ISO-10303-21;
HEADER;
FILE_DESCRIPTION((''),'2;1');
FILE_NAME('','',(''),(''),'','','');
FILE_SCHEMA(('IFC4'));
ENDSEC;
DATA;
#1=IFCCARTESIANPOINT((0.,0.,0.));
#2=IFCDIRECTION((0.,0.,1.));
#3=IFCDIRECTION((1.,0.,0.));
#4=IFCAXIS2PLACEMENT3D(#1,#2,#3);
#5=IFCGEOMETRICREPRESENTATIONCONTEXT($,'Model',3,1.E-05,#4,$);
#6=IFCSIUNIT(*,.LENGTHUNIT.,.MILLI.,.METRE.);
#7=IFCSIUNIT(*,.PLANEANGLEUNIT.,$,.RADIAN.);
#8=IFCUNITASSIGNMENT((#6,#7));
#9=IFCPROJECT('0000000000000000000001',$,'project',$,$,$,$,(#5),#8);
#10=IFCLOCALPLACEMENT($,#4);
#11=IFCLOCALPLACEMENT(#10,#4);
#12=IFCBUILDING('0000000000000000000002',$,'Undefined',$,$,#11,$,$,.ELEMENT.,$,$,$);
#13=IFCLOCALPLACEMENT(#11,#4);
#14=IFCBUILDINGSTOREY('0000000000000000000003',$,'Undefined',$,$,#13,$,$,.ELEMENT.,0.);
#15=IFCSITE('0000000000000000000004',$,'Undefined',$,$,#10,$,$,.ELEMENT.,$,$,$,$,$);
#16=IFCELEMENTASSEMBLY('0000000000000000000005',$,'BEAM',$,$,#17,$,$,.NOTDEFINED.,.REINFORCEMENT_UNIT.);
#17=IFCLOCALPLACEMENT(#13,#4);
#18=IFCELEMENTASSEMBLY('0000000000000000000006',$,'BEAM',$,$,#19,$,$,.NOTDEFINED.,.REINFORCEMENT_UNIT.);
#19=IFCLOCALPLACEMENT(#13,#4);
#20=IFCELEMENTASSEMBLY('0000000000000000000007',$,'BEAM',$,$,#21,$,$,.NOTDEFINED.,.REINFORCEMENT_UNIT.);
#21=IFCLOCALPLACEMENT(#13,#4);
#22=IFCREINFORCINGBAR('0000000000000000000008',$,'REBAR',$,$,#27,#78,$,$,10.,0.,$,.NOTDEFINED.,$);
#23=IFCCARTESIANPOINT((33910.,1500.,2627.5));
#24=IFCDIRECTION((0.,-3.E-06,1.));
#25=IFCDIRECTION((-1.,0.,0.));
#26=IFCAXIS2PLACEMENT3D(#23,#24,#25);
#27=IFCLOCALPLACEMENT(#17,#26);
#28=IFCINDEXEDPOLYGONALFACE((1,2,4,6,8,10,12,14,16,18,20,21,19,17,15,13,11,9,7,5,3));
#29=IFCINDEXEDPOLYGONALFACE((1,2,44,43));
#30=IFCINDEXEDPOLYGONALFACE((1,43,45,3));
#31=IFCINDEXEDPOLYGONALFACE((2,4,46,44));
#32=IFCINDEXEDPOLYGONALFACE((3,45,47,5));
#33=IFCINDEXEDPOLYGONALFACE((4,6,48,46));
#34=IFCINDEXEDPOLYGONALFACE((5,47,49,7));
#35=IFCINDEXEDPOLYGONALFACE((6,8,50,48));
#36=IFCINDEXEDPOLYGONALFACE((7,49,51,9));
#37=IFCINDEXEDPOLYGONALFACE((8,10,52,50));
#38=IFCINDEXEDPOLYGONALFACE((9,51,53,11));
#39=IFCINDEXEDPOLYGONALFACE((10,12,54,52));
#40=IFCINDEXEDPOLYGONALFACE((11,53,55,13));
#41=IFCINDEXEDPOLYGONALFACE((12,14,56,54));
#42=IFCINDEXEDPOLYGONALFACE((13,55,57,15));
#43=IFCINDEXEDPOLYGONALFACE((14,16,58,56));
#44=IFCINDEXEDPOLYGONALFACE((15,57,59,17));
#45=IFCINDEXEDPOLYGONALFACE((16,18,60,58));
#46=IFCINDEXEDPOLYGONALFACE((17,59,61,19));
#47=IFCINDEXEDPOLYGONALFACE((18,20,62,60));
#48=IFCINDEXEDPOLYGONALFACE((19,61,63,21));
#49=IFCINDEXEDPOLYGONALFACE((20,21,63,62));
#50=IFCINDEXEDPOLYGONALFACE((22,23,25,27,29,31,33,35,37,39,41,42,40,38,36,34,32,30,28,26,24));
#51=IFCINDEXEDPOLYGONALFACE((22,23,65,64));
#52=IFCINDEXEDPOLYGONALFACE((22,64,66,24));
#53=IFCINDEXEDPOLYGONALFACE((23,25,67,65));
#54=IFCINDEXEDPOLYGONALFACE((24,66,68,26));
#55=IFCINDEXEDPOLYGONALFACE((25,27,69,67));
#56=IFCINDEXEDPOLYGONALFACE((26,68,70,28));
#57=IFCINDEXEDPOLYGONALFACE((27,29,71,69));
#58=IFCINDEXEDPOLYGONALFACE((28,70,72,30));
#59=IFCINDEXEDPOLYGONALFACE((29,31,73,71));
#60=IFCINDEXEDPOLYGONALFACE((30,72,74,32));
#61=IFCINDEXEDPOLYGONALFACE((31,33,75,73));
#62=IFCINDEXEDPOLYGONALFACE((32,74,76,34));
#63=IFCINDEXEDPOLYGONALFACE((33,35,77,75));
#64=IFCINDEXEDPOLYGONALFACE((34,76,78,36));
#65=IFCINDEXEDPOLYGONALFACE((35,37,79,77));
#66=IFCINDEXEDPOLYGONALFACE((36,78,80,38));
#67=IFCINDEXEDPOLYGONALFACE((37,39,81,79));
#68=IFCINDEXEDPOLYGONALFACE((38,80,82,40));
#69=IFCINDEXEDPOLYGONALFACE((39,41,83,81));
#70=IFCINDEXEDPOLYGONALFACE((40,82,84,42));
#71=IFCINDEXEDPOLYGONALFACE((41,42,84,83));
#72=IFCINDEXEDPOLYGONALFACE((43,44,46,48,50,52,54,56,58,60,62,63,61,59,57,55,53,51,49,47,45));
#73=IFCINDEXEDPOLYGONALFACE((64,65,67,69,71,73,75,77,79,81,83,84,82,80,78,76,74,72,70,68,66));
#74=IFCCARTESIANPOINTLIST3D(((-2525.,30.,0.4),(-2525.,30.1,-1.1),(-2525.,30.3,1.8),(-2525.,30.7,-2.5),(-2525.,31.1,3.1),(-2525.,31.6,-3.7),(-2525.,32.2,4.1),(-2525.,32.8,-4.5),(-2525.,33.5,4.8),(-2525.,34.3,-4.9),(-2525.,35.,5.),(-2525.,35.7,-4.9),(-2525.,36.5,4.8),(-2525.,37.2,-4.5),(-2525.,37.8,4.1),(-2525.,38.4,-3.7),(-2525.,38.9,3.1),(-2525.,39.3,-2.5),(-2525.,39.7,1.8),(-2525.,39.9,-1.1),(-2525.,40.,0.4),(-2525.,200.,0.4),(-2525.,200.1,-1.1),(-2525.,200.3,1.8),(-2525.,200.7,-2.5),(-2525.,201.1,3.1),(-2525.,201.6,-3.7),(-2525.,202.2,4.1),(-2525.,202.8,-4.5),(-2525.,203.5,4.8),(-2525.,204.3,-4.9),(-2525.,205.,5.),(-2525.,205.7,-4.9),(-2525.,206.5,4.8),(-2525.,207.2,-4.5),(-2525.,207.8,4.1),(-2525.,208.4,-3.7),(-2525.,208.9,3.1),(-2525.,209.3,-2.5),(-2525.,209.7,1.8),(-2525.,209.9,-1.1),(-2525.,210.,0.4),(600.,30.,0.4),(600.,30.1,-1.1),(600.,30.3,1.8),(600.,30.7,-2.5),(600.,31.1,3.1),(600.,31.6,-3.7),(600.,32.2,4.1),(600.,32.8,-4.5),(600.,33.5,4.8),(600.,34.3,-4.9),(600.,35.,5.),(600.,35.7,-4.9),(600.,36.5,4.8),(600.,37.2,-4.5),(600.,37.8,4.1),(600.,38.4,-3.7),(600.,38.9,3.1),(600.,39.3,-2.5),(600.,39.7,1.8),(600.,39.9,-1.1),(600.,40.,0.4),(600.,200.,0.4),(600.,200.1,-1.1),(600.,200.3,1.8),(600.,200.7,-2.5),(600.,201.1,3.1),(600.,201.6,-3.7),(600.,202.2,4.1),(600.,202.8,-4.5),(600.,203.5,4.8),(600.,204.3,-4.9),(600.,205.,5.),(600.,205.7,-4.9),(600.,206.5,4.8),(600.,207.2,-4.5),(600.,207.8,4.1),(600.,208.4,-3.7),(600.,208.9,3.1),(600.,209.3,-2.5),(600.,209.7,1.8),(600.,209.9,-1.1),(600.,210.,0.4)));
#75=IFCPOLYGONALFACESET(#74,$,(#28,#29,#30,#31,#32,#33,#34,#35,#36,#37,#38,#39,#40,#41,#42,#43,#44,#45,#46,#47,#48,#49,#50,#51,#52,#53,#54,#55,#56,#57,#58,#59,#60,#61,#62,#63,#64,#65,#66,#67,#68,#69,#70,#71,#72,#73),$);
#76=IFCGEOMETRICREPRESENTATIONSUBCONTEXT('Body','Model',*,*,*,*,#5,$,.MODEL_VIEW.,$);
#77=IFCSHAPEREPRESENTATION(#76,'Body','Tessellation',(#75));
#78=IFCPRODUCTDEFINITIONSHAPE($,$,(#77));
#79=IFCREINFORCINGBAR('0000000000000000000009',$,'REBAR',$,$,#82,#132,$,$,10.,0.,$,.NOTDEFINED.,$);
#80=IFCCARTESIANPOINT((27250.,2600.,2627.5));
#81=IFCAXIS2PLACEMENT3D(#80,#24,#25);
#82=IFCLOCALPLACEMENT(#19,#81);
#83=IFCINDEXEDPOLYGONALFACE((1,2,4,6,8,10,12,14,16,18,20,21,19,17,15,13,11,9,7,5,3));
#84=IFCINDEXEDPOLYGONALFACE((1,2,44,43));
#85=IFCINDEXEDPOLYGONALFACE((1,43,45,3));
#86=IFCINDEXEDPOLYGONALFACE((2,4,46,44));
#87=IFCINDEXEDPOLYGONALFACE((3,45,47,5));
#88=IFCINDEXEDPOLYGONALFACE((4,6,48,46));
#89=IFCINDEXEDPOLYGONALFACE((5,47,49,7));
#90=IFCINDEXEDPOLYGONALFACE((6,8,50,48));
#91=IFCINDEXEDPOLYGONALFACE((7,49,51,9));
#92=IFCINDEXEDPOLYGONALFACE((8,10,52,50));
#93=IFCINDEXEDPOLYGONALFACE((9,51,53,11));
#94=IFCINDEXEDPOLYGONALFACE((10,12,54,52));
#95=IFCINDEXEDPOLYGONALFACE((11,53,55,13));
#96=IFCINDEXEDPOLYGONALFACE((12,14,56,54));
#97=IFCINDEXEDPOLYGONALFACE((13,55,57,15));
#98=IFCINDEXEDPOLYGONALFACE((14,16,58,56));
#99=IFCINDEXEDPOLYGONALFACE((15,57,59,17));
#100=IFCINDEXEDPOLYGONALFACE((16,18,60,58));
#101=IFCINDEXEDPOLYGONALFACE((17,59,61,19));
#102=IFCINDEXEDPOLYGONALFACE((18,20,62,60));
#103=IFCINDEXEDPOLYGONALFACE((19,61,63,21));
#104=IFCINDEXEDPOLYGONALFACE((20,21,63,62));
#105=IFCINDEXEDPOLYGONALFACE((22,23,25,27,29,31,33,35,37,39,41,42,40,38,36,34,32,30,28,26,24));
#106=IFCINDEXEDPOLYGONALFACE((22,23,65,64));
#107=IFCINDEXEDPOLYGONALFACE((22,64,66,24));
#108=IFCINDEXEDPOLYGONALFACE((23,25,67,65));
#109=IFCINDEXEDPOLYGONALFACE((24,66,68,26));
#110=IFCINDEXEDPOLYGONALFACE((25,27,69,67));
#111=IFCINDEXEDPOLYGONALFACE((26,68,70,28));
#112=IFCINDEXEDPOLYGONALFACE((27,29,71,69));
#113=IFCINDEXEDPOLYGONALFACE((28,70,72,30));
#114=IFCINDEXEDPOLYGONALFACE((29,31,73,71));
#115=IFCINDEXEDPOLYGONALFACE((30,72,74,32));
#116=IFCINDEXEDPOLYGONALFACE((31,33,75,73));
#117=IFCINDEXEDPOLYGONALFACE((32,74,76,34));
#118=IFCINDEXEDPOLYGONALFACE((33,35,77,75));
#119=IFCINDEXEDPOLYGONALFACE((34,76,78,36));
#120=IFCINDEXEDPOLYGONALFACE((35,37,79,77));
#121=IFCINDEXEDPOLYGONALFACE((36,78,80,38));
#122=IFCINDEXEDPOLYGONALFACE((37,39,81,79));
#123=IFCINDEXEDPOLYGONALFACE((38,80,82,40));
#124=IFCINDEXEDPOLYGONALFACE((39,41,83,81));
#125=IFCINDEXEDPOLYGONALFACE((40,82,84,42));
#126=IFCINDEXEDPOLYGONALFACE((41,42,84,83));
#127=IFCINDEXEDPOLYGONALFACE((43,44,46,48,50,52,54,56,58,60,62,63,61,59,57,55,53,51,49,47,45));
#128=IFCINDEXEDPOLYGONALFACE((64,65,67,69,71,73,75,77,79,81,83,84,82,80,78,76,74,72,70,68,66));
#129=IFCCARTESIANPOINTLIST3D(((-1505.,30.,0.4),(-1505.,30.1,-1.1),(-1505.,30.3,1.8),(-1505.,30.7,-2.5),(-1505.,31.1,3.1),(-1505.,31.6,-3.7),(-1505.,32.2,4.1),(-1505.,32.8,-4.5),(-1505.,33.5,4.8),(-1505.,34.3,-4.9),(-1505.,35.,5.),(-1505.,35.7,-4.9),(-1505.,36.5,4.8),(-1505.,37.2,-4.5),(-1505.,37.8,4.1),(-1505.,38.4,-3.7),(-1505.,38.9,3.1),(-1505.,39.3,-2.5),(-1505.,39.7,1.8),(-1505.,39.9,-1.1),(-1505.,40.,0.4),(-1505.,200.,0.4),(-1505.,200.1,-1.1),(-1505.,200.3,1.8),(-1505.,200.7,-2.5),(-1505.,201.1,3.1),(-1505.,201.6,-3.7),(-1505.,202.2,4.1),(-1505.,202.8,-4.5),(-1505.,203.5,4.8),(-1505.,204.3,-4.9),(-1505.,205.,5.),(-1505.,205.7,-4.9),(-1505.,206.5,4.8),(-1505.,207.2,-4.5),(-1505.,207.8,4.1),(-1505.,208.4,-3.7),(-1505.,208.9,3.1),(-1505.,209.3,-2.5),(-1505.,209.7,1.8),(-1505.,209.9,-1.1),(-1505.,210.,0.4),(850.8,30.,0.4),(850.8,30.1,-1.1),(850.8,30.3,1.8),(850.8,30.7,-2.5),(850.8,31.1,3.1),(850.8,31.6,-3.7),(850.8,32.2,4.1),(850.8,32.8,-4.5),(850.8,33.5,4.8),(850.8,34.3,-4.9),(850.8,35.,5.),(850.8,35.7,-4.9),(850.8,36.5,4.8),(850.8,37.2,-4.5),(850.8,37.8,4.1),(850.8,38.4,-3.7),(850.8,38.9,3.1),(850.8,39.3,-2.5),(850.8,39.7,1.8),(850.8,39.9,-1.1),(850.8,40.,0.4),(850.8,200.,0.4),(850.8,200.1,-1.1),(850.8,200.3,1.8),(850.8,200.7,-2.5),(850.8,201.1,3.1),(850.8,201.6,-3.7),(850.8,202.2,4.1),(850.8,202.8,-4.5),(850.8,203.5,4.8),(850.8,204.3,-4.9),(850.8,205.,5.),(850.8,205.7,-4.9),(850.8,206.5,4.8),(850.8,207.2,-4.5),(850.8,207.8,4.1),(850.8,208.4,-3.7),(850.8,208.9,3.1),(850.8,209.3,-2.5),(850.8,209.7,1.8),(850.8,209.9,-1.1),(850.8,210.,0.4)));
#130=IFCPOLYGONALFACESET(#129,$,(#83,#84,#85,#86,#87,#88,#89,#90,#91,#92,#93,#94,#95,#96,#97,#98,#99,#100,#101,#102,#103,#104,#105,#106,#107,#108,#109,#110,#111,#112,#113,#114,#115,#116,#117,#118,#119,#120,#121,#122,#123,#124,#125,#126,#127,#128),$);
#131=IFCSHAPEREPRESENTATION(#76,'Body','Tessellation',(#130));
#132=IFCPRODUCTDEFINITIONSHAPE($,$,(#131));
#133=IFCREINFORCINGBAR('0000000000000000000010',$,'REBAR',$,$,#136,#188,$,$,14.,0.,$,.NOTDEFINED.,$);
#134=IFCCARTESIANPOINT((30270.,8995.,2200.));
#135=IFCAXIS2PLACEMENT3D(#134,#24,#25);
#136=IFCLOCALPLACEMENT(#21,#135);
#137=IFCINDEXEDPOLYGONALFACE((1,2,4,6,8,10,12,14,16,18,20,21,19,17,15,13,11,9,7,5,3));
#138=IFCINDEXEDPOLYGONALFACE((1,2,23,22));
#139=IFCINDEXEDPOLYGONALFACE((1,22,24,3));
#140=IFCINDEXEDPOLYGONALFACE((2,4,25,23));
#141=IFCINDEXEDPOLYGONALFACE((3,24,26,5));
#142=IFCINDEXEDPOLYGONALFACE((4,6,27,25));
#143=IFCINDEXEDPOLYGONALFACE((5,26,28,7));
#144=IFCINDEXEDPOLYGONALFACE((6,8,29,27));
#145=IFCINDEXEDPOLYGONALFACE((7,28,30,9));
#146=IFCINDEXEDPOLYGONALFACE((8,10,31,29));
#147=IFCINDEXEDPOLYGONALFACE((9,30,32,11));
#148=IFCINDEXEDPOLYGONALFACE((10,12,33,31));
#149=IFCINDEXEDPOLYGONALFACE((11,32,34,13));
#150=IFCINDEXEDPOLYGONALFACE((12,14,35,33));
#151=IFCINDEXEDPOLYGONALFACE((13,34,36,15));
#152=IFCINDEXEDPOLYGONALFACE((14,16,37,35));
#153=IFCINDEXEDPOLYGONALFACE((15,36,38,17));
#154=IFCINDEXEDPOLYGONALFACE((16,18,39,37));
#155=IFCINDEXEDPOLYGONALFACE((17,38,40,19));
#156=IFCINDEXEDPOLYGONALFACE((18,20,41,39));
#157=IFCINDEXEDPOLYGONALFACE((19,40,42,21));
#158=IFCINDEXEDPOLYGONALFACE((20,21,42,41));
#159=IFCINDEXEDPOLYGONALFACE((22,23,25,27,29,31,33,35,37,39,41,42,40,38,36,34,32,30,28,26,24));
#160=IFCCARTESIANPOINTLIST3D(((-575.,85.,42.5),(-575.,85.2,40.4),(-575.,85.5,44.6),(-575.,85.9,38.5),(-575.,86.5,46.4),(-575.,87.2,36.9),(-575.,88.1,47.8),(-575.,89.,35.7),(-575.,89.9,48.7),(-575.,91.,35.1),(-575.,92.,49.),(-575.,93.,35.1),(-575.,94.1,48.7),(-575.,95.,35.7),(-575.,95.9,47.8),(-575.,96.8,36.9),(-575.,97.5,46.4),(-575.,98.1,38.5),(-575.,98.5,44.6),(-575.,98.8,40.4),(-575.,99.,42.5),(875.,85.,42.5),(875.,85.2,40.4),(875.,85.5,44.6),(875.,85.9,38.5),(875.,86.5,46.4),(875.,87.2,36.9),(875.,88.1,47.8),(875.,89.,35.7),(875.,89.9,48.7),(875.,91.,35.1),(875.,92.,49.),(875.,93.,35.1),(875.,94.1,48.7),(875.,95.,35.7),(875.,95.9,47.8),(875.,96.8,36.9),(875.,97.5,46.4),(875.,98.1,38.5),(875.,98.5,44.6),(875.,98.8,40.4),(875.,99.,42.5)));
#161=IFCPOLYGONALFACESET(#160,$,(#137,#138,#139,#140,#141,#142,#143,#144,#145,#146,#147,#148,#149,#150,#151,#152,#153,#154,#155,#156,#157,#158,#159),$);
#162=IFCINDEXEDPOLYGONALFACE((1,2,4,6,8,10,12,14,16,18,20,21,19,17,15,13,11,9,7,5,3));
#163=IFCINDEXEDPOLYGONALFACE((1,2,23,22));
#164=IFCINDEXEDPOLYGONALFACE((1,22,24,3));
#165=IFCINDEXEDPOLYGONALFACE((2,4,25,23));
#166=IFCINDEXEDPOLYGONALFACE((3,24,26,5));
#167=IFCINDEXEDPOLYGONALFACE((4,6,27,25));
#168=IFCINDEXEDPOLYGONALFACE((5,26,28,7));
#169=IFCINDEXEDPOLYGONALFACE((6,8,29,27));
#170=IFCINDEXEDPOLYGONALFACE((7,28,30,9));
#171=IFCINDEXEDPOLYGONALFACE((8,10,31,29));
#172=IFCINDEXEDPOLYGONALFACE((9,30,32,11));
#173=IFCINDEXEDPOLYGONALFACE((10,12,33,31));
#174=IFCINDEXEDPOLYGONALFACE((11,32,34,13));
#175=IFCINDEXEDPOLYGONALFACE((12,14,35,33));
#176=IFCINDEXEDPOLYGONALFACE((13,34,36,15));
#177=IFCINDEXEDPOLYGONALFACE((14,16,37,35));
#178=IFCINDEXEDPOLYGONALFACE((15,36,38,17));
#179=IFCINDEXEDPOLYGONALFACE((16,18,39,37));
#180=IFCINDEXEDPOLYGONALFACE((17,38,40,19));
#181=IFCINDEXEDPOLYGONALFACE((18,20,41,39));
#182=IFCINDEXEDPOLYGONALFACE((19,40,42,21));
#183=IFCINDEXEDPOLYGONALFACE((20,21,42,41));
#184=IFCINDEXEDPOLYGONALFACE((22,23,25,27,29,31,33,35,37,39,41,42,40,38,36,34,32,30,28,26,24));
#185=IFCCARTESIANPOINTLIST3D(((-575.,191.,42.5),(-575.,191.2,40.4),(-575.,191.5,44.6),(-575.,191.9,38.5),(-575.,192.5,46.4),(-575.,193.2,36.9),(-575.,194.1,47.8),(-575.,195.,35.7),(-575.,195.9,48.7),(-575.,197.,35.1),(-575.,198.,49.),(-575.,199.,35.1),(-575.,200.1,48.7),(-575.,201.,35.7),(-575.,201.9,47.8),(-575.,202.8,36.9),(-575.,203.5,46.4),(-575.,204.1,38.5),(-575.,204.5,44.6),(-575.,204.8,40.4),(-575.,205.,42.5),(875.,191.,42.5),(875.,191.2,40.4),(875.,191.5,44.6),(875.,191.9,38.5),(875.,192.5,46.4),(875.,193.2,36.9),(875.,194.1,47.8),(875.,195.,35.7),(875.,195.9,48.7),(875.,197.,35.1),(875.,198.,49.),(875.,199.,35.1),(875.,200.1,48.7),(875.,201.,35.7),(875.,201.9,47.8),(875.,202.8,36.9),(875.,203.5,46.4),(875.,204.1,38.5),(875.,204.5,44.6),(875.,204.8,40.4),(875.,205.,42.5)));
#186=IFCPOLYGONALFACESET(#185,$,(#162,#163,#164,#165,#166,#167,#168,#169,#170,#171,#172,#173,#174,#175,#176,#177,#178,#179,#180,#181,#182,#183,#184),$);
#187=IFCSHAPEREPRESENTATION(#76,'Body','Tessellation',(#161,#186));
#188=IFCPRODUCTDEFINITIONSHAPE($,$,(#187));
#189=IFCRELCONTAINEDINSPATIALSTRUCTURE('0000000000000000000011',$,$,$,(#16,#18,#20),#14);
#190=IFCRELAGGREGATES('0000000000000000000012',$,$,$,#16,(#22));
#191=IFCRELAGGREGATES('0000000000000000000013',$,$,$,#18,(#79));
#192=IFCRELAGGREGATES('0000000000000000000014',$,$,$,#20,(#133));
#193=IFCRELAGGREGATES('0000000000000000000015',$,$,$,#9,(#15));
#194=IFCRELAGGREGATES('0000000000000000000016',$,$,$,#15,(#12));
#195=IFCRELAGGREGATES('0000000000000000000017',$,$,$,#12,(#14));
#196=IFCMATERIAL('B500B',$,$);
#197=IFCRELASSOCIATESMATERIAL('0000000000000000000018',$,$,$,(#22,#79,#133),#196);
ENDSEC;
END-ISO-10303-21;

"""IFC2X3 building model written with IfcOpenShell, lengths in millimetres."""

from ifc_helpers import new_model, entity, si_unit, frame, origin_with_axes, place, context, subcontext, project, spatial, source, transform, mapped, material, element, aggregate, save


model = new_model("IFC2X3")

# Units and contexts
model_context = context("Model", 3, precision=1e-05, world=origin_with_axes())
body_context = subcontext(model_context, "Body", "Model", "MODEL_VIEW")
ifc_project = project(units=[si_unit("LENGTHUNIT", "METRE", prefix="MILLI"), si_unit("PLANEANGLEUNIT", "RADIAN")], contexts=[model_context])

# Site, building, storey
site_placement = place(None, origin_with_axes())
site = spatial("IfcSite", under=ifc_project, at=site_placement, Name="Undefined", CompositionType="ELEMENT")
building_placement = place(site_placement, origin_with_axes())
building = spatial("IfcBuilding", under=site, at=building_placement, Name="Undefined", CompositionType="ELEMENT")
storey_placement = place(building_placement, origin_with_axes())
storey = spatial("IfcBuildingStorey", under=building, at=storey_placement, Name="Undefined", CompositionType="ELEMENT", Elevation=0.0)

# Element assembly
assembly_1_placement = place(storey_placement, origin_with_axes())
assembly_1 = element("IfcElementAssembly", 1, at=assembly_1_placement, inside=storey, Name="BEAM", AssemblyPlace="NOTDEFINED", PredefinedType="REINFORCEMENT_UNIT")

# Element assembly
assembly_2_placement = place(storey_placement, origin_with_axes())
assembly_2 = element("IfcElementAssembly", 2, at=assembly_2_placement, inside=storey, Name="BEAM", AssemblyPlace="NOTDEFINED", PredefinedType="REINFORCEMENT_UNIT")

# Element assembly
assembly_3_placement = place(storey_placement, origin_with_axes())
assembly_3 = element("IfcElementAssembly", 3, at=assembly_3_placement, inside=storey, Name="BEAM", AssemblyPlace="NOTDEFINED", PredefinedType="REINFORCEMENT_UNIT")

# Reinforcing bars
ifc_material_1 = material(Name="B500B")
shared_shape_1 = source(origin_with_axes(), body_context, "Body", "AdvancedSweptSolid", [
    entity("IfcSweptDiskSolid", entity("IfcTrimmedCurve", entity("IfcLine", entity("IfcCartesianPoint", [0.0, 0.0, 0.0]), entity("IfcVector", entity("IfcDirection", [1.0, 0.0, 0.0]), 1.0)), [entity("IfcParameterValue", 0.0)], [entity("IfcParameterValue", 3125.002834)], True, "PARAMETER"), 5.0, None, 0.0, 3125.0),
])
shared_shape_2 = source(origin_with_axes(), body_context, "Body", "AdvancedSweptSolid", [
    entity("IfcSweptDiskSolid", entity("IfcTrimmedCurve", entity("IfcLine", entity("IfcCartesianPoint", [0.0, 0.0, 0.0]), entity("IfcVector", entity("IfcDirection", [1.0, 0.0, 0.0]), 1.0)), [entity("IfcParameterValue", 0.0)], [entity("IfcParameterValue", 3125.002834)], True, "PARAMETER"), 5.0, None, 0.0, 3125.0),
])
reinforcing_bar_1_placement = place(assembly_1_placement, frame((33910.0, 1500.0, 2627.5), z_axis=(0.0, -0.000003, 1.0), x_axis=(-1.0, 0.0, 0.0)))
reinforcing_bar_1 = element("IfcReinforcingBar", 4, at=reinforcing_bar_1_placement, material=ifc_material_1, Name="REBAR", BarRole="NOTDEFINED", CrossSectionArea=0.0, NominalDiameter=10.0, context=body_context, shape_type="MappedRepresentation", body=[
    mapped(shared_shape_1, transform((-2525.0, 35.0, 0.0))),
    mapped(shared_shape_2, transform((-2525.0, 205.0, 0.0))),
])
aggregate(assembly_1, [reinforcing_bar_1])
shared_shape_3 = source(origin_with_axes(), body_context, "Body", "AdvancedSweptSolid", [
    entity("IfcSweptDiskSolid", entity("IfcTrimmedCurve", entity("IfcLine", entity("IfcCartesianPoint", [0.0, 0.0, 0.0]), entity("IfcVector", entity("IfcDirection", [1.0, 0.0, 0.0]), 1.0)), [entity("IfcParameterValue", 0.0)], [entity("IfcParameterValue", 2355.822834)], True, "PARAMETER"), 5.0, None, 0.0, 2355.8),
])
shared_shape_4 = source(origin_with_axes(), body_context, "Body", "AdvancedSweptSolid", [
    entity("IfcSweptDiskSolid", entity("IfcTrimmedCurve", entity("IfcLine", entity("IfcCartesianPoint", [0.0, 0.0, 0.0]), entity("IfcVector", entity("IfcDirection", [1.0, 0.0, 0.0]), 1.0)), [entity("IfcParameterValue", 0.0)], [entity("IfcParameterValue", 2355.822834)], True, "PARAMETER"), 5.0, None, 0.0, 2355.8),
])
reinforcing_bar_2_placement = place(assembly_2_placement, frame((27250.0, 2600.0, 2627.5), z_axis=(0.0, -0.000003, 1.0), x_axis=(-1.0, 0.0, 0.0)))
reinforcing_bar_2 = element("IfcReinforcingBar", 5, at=reinforcing_bar_2_placement, material=ifc_material_1, Name="REBAR", BarRole="NOTDEFINED", CrossSectionArea=0.0, NominalDiameter=10.0, context=body_context, shape_type="MappedRepresentation", body=[
    mapped(shared_shape_3, transform((-1505.0, 35.0, 0.0))),
    mapped(shared_shape_4, transform((-1505.0, 205.0, 0.0))),
])
aggregate(assembly_2, [reinforcing_bar_2])
shared_shape_5 = source(origin_with_axes(), body_context, "Body", "AdvancedSweptSolid", [
    entity("IfcSweptDiskSolid", entity("IfcTrimmedCurve", entity("IfcLine", entity("IfcCartesianPoint", [0.0, 0.0, 0.0]), entity("IfcVector", entity("IfcDirection", [1.0, 0.0, 0.0]), 1.0)), [entity("IfcParameterValue", 0.0)], [entity("IfcParameterValue", 1449.999613)], True, "PARAMETER"), 7.0, None, 0.0, 1450.0),
])
shared_shape_6 = source(origin_with_axes(), body_context, "Body", "AdvancedSweptSolid", [
    entity("IfcSweptDiskSolid", entity("IfcTrimmedCurve", entity("IfcLine", entity("IfcCartesianPoint", [0.0, 0.0, 0.0]), entity("IfcVector", entity("IfcDirection", [1.0, 0.0, 0.0]), 1.0)), [entity("IfcParameterValue", 0.0)], [entity("IfcParameterValue", 1449.999613)], True, "PARAMETER"), 7.0, None, 0.0, 1450.0),
])
reinforcing_bar_3_placement = place(assembly_3_placement, frame((30270.0, 8995.0, 2200.0), z_axis=(0.0, -0.000003, 1.0), x_axis=(-1.0, 0.0, 0.0)))
reinforcing_bar_3 = element("IfcReinforcingBar", 6, at=reinforcing_bar_3_placement, material=ifc_material_1, Name="REBAR", BarRole="NOTDEFINED", CrossSectionArea=0.0, NominalDiameter=14.0, context=body_context, shape_type="MappedRepresentation", body=[
    mapped(shared_shape_5, transform((-575.0, 92.0, 42.0))),
    mapped(shared_shape_6, transform((-575.0, 198.0, 42.0))),
])
aggregate(assembly_3, [reinforcing_bar_3])

save(model, "model.ifc")
